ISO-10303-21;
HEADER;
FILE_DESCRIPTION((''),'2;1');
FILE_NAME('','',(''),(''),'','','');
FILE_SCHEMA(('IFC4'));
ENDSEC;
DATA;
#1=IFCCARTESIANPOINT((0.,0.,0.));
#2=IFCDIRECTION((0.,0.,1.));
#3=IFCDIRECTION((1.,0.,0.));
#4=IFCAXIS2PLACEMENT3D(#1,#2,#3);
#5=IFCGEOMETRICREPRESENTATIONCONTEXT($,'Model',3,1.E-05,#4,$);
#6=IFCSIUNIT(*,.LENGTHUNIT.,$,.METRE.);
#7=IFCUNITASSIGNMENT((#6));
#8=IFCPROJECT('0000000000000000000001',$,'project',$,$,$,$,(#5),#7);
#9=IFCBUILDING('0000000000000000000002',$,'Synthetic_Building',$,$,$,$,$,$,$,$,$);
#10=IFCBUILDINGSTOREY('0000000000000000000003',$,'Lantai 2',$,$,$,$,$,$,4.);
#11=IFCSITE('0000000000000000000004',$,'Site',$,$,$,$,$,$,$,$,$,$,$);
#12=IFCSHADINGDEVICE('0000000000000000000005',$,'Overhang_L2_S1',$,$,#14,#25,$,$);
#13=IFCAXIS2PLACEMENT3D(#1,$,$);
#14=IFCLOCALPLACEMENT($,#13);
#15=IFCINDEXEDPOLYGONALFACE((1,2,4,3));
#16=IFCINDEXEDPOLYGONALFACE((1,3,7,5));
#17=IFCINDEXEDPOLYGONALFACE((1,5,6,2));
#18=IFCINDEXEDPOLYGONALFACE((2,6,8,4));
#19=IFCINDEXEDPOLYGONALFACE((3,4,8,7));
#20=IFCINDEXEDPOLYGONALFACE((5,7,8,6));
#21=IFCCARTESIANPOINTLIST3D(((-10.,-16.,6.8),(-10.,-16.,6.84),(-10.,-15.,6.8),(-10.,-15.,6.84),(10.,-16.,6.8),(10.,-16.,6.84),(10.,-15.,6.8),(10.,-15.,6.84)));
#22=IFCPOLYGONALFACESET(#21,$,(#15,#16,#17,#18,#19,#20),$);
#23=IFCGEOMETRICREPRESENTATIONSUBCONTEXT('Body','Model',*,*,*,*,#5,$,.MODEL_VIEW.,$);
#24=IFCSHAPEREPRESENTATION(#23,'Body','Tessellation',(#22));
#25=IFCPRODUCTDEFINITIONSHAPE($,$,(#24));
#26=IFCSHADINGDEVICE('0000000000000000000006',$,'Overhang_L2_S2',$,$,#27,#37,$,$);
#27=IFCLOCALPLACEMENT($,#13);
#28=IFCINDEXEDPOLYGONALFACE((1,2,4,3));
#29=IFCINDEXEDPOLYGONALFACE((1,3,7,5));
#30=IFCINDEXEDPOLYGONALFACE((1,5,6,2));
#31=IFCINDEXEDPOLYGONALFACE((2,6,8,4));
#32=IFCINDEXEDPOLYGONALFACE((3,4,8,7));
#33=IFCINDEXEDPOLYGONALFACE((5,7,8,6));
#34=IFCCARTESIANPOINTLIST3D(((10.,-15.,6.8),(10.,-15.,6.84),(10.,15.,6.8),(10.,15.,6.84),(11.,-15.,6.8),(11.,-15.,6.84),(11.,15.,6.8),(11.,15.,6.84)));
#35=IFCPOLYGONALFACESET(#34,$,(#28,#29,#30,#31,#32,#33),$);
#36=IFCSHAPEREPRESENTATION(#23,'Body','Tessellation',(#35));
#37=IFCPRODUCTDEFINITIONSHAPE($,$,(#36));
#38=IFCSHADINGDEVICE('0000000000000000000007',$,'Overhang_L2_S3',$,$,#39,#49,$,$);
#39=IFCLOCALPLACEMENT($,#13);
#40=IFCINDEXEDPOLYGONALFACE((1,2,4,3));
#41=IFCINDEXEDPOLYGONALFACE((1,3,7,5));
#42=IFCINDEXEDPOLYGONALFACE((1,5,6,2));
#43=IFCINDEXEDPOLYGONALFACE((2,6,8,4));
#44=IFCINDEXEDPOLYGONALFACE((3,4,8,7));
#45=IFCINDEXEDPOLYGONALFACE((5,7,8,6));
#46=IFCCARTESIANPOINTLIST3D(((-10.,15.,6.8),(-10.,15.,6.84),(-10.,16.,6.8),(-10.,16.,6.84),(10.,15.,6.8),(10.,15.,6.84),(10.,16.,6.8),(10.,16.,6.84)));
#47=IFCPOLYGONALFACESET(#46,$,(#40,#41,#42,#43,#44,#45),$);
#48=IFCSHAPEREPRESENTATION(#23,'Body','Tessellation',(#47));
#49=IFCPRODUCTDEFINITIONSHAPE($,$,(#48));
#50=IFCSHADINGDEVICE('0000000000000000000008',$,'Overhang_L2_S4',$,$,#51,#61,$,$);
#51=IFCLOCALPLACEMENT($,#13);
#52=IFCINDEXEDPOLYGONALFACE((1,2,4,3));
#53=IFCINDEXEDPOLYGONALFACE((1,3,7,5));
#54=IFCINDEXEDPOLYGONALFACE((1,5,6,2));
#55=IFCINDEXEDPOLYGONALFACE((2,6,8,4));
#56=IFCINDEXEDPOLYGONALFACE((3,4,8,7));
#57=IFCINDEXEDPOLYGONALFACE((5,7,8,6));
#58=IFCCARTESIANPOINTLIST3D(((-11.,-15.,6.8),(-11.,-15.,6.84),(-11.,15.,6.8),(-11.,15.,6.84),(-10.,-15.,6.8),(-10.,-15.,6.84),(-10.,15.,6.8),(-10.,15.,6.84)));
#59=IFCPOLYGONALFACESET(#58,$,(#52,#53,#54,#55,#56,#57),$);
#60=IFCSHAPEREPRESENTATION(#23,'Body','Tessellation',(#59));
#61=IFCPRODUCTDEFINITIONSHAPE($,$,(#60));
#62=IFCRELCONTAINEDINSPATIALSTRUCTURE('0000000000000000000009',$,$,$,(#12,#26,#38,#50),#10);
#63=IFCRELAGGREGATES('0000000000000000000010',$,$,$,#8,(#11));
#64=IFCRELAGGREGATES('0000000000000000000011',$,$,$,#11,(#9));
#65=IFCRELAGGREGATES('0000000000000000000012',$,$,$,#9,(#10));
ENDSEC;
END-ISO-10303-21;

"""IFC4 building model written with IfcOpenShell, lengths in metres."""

from ifc_helpers import new_model, si_unit, frame, origin_with_axes, place, context, subcontext, project, spatial, polyline, outline, extrude, element, save


model = new_model("IFC4")

# Units and contexts
model_context = context("Model", 3, precision=1e-05, world=origin_with_axes())
body_context = subcontext(model_context, "Body", "Model", "MODEL_VIEW")
ifc_project = project(units=[si_unit("LENGTHUNIT", "METRE")], contexts=[model_context])

# Site, building, storey
site = spatial("IfcSite", under=ifc_project, Name="Site")
building = spatial("IfcBuilding", under=site, Name="Synthetic_Building")
storey = spatial("IfcBuildingStorey", under=building, Name="Lantai 2", Elevation=4.0)

# Shading devices
shading_device_1_placement = place(None, origin_with_axes())
element("IfcShadingDevice", 1, at=shading_device_1_placement, inside=storey, Name="Overhang_L2_S1", context=body_context, shape_type="SweptSolid", body=[
    extrude(outline(polyline([(-10.0, -15.0), (-10.0, -16.0), (10.0, -16.0), (10.0, -15.0), (-10.0, -15.0)])), frame((0.0, 0.0, 6.8), z_axis=(0.0, 0.0, 1.0), x_axis=(1.0, 0.0, 0.0)), (0.0, 0.0, 1.0), 0.04),
])
shading_device_2_placement = place(None, origin_with_axes())
element("IfcShadingDevice", 2, at=shading_device_2_placement, inside=storey, Name="Overhang_L2_S2", context=body_context, shape_type="SweptSolid", body=[
    extrude(outline(polyline([(10.0, -15.0), (11.0, -15.0), (11.0, 15.0), (10.0, 15.0), (10.0, -15.0)])), frame((0.0, 0.0, 6.8), z_axis=(0.0, 0.0, 1.0), x_axis=(1.0, 0.0, 0.0)), (0.0, 0.0, 1.0), 0.04),
])
shading_device_3_placement = place(None, origin_with_axes())
element("IfcShadingDevice", 3, at=shading_device_3_placement, inside=storey, Name="Overhang_L2_S3", context=body_context, shape_type="SweptSolid", body=[
    extrude(outline(polyline([(10.0, 15.0), (10.0, 16.0), (-10.0, 16.0), (-10.0, 15.0), (10.0, 15.0)])), frame((0.0, 0.0, 6.8), z_axis=(0.0, 0.0, 1.0), x_axis=(1.0, 0.0, 0.0)), (0.0, 0.0, 1.0), 0.04),
])
shading_device_4_placement = place(None, origin_with_axes())
element("IfcShadingDevice", 4, at=shading_device_4_placement, inside=storey, Name="Overhang_L2_S4", context=body_context, shape_type="SweptSolid", body=[
    extrude(outline(polyline([(-10.0, 15.0), (-11.0, 15.0), (-11.0, -15.0), (-10.0, -15.0), (-10.0, 15.0)])), frame((0.0, 0.0, 6.8), z_axis=(0.0, 0.0, 1.0), x_axis=(1.0, 0.0, 0.0)), (0.0, 0.0, 1.0), 0.04),
])

save(model, "model.ifc")
